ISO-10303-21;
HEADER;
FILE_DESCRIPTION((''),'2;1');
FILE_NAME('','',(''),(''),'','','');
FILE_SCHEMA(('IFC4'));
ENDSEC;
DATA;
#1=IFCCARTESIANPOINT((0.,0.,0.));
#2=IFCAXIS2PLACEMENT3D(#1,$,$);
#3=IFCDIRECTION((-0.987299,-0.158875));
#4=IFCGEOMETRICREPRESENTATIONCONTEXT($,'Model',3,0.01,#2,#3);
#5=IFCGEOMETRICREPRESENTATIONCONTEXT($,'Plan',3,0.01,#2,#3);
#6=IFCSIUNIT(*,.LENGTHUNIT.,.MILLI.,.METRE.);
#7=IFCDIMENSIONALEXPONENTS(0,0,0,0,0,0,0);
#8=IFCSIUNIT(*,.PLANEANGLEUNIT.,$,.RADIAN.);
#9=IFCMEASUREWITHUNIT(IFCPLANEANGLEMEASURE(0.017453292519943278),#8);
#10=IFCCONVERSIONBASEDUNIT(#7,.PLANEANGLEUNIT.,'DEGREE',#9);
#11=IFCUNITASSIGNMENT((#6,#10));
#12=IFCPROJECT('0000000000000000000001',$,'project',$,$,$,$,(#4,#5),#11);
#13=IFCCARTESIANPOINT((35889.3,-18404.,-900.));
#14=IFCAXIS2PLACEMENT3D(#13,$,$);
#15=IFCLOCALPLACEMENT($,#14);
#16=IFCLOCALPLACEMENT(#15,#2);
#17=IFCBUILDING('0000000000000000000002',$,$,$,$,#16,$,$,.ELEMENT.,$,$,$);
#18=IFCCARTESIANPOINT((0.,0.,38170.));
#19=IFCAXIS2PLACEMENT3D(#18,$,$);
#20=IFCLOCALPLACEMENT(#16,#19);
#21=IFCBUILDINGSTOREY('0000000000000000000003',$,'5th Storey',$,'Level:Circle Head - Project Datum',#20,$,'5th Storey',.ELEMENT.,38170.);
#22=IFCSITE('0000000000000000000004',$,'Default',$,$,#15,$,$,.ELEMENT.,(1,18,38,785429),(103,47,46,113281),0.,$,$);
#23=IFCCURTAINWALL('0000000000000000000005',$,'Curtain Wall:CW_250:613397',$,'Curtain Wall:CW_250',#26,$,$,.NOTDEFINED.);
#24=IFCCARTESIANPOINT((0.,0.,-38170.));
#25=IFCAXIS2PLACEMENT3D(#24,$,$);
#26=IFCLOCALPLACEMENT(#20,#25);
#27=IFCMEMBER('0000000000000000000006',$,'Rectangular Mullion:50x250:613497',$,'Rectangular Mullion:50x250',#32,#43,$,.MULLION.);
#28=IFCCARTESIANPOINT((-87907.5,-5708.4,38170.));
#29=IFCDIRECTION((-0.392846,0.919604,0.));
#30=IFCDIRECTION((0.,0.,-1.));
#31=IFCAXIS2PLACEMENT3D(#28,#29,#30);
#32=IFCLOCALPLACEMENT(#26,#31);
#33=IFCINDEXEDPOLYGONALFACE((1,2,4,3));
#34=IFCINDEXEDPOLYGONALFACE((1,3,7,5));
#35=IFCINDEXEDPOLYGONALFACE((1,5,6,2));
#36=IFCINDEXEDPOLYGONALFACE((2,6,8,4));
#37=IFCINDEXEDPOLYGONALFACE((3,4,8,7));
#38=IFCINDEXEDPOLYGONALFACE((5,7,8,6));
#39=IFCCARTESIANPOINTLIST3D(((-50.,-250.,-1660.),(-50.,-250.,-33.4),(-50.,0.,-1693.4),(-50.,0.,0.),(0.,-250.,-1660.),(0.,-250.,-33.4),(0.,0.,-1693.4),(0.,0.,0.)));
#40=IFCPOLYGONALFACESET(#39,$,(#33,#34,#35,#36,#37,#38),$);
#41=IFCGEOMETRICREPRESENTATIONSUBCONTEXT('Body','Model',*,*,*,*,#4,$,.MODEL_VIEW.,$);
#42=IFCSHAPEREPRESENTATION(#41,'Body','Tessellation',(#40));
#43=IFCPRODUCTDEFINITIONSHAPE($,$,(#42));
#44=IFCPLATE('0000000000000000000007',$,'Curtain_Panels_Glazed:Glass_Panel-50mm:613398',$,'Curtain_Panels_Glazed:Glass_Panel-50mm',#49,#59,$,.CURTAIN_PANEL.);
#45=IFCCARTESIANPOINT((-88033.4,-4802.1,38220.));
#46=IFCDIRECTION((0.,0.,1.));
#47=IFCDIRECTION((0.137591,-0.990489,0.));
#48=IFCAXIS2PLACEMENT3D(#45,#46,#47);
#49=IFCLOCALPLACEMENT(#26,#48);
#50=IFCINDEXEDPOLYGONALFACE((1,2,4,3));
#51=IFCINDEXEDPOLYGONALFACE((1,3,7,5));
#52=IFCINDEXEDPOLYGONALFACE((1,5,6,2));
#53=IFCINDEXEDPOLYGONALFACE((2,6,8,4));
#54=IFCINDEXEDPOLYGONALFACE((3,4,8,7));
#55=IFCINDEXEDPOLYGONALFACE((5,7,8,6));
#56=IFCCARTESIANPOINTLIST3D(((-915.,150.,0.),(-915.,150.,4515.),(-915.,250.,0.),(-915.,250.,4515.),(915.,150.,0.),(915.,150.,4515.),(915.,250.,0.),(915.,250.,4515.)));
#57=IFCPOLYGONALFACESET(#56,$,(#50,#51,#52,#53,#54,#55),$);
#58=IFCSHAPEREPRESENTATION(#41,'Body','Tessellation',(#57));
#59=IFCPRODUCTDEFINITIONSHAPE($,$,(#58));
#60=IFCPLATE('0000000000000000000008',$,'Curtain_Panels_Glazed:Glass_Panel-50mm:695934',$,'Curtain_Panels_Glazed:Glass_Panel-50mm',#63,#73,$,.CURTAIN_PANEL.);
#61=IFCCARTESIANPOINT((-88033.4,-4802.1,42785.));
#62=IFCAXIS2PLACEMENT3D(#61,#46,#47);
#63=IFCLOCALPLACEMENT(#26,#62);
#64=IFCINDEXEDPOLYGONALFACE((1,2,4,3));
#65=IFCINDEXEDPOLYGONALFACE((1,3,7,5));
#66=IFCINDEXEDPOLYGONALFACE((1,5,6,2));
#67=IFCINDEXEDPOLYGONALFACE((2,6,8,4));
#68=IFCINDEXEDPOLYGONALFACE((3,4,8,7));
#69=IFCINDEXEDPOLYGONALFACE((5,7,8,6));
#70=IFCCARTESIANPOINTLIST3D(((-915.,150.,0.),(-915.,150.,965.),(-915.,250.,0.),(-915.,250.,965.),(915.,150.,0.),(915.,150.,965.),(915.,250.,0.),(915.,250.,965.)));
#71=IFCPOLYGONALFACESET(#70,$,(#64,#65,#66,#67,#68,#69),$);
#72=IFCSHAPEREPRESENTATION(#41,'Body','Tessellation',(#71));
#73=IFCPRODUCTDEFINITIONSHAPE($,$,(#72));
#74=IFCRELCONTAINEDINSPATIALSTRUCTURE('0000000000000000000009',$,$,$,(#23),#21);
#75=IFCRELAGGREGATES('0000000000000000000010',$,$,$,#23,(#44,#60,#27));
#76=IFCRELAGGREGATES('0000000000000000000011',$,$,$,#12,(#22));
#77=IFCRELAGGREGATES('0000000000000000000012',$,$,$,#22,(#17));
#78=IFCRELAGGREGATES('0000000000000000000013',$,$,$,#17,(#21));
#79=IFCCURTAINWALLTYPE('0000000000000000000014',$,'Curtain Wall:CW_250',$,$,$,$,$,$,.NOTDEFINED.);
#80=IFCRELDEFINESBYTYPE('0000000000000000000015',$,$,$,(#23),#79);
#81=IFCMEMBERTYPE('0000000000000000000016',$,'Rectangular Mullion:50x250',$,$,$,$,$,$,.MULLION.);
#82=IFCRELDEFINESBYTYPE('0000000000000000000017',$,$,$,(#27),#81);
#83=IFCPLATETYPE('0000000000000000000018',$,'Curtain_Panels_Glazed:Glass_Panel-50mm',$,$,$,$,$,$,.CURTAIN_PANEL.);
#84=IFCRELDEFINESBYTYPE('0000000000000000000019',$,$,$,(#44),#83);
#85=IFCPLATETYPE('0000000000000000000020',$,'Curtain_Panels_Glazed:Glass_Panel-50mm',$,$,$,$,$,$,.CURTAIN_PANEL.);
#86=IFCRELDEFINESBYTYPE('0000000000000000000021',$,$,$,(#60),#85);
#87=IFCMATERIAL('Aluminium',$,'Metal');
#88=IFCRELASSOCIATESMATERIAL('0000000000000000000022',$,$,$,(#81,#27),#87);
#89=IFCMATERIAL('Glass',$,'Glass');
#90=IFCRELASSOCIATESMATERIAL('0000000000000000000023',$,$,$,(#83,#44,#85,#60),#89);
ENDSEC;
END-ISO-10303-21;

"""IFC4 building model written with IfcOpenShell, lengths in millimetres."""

from ifc_helpers import new_model, entity, si_unit, converted_unit, direction, frame, origin, place, context, subcontext, project, spatial, indexed_curve, outline, extrude, source, transform, mapped, material, type_object, type_shapes, element, aggregate, save


model = new_model("IFC4")

# Units and contexts
model_context = context("Model", 3, precision=0.01, world=origin(), true_north=direction((-0.987299, -0.158875)))
plan_context = context("Plan", 3, precision=0.01, world=origin(), true_north=direction((-0.987299, -0.158875)))
body_context = subcontext(model_context, "Body", "Model", "MODEL_VIEW")
ifc_project = project(units=[si_unit("LENGTHUNIT", "METRE", prefix="MILLI"), converted_unit("PLANEANGLEUNIT", "DEGREE", entity("IfcPlaneAngleMeasure", 0.017453292519943278), si_unit("PLANEANGLEUNIT", "RADIAN"), dimensions=[0, 0, 0, 0, 0, 0, 0])], contexts=[model_context, plan_context])

# Site, building, storey
site_placement = place(None, frame((35889.3, -18404.0, -900.0)))
site = spatial("IfcSite", under=ifc_project, at=site_placement, Name="Default", CompositionType="ELEMENT", RefLatitude=(1, 18, 38, 785429), RefLongitude=(103, 47, 46, 113281), RefElevation=0.0)
building_placement = place(site_placement, origin())
building = spatial("IfcBuilding", under=site, at=building_placement, CompositionType="ELEMENT")
storey_placement = place(building_placement, frame((0.0, 0.0, 38170.0)))
storey = spatial("IfcBuildingStorey", under=building, at=storey_placement, Name="5th Storey", ObjectType="Level:Circle Head - Project Datum", LongName="5th Storey", CompositionType="ELEMENT", Elevation=38170.0)

# Curtain wall, member
curtain_wall_type = type_object("IfcCurtainWallType", Name="Curtain Wall:CW_250", PredefinedType="NOTDEFINED")
ifc_material_1 = material(Name="Aluminium", Category="Metal")
curtain_wall_1_placement = place(storey_placement, frame((0.0, 0.0, -38170.0)))
curtain_wall_1 = element("IfcCurtainWall", 1, at=curtain_wall_1_placement, inside=storey, type_object=curtain_wall_type, Name="Curtain Wall:CW_250:613397", ObjectType="Curtain Wall:CW_250", PredefinedType="NOTDEFINED")
member_type_1 = type_object("IfcMemberType", Name="Rectangular Mullion:50x250", PredefinedType="MULLION", material=ifc_material_1)
shared_shape_1 = source(origin(), body_context, "Body", "SweptSolid", [
    extrude(outline(indexed_curve([(-813.3, -125.0), (813.3, -125.0), (846.7, 125.0), (-846.7, 125.0), (-813.3, -125.0)], self_intersect=False)), frame((-50.0, -125.0, -846.7), z_axis=(1.0, 0.0, 0.0), x_axis=(0.0, 0.0, -1.0)), (0.0, 0.0, 1.0), 50.0),
])
type_shapes(member_type_1, [shared_shape_1])
member_1_placement = place(curtain_wall_1_placement, frame((-87907.5, -5708.4, 38170.0), z_axis=(-0.392846, 0.919604, 0.0), x_axis=(0.0, 0.0, -1.0)))
member_1 = element("IfcMember", 2, at=member_1_placement, type_object=member_type_1, material=ifc_material_1, Name="Rectangular Mullion:50x250:613497", ObjectType="Rectangular Mullion:50x250", PredefinedType="MULLION", context=body_context, shape_type="MappedRepresentation", body=[
    mapped(shared_shape_1, transform((0.0, 0.0, 0.0), scale=1.0)),
])

# Plates
ifc_material_2 = material(Name="Glass", Category="Glass")
plate_type_1 = type_object("IfcPlateType", Name="Curtain_Panels_Glazed:Glass_Panel-50mm", PredefinedType="CURTAIN_PANEL", material=ifc_material_2)
shared_shape_2 = source(origin(), body_context, "Body", "SweptSolid", [
    extrude(outline(indexed_curve([(-50.0, -915.0), (50.0, -915.0), (50.0, 915.0), (-50.0, 915.0), (-50.0, -915.0)], self_intersect=False)), frame((0.0, 200.0, 0.0), z_axis=(0.0, 0.0, 1.0), x_axis=(0.0, 1.0, 0.0)), (0.0, 0.0, 1.0), 4515.0),
])
type_shapes(plate_type_1, [shared_shape_2])
plate_1_placement = place(curtain_wall_1_placement, frame((-88033.4, -4802.1, 38220.0), z_axis=(0.0, 0.0, 1.0), x_axis=(0.137591, -0.990489, 0.0)))
plate_1 = element("IfcPlate", 3, at=plate_1_placement, type_object=plate_type_1, material=ifc_material_2, Name="Curtain_Panels_Glazed:Glass_Panel-50mm:613398", ObjectType="Curtain_Panels_Glazed:Glass_Panel-50mm", PredefinedType="CURTAIN_PANEL", context=body_context, shape_type="MappedRepresentation", body=[
    mapped(shared_shape_2, transform((0.0, 0.0, 0.0), scale=1.0)),
])
plate_type_2 = type_object("IfcPlateType", Name="Curtain_Panels_Glazed:Glass_Panel-50mm", PredefinedType="CURTAIN_PANEL", material=ifc_material_2)
shared_shape_3 = source(origin(), body_context, "Body", "SweptSolid", [
    extrude(outline(indexed_curve([(-50.0, -915.0), (50.0, -915.0), (50.0, 915.0), (-50.0, 915.0), (-50.0, -915.0)], self_intersect=False)), frame((0.0, 200.0, 0.0), z_axis=(0.0, 0.0, 1.0), x_axis=(0.0, 1.0, 0.0)), (0.0, 0.0, 1.0), 965.0),
])
type_shapes(plate_type_2, [shared_shape_3])
plate_2_placement = place(curtain_wall_1_placement, frame((-88033.4, -4802.1, 42785.0), z_axis=(0.0, 0.0, 1.0), x_axis=(0.137591, -0.990489, 0.0)))
plate_2 = element("IfcPlate", 4, at=plate_2_placement, type_object=plate_type_2, material=ifc_material_2, Name="Curtain_Panels_Glazed:Glass_Panel-50mm:695934", ObjectType="Curtain_Panels_Glazed:Glass_Panel-50mm", PredefinedType="CURTAIN_PANEL", context=body_context, shape_type="MappedRepresentation", body=[
    mapped(shared_shape_3, transform((0.0, 0.0, 0.0), scale=1.0)),
])
aggregate(curtain_wall_1, [plate_1, plate_2, member_1])

save(model, "model.ifc")
